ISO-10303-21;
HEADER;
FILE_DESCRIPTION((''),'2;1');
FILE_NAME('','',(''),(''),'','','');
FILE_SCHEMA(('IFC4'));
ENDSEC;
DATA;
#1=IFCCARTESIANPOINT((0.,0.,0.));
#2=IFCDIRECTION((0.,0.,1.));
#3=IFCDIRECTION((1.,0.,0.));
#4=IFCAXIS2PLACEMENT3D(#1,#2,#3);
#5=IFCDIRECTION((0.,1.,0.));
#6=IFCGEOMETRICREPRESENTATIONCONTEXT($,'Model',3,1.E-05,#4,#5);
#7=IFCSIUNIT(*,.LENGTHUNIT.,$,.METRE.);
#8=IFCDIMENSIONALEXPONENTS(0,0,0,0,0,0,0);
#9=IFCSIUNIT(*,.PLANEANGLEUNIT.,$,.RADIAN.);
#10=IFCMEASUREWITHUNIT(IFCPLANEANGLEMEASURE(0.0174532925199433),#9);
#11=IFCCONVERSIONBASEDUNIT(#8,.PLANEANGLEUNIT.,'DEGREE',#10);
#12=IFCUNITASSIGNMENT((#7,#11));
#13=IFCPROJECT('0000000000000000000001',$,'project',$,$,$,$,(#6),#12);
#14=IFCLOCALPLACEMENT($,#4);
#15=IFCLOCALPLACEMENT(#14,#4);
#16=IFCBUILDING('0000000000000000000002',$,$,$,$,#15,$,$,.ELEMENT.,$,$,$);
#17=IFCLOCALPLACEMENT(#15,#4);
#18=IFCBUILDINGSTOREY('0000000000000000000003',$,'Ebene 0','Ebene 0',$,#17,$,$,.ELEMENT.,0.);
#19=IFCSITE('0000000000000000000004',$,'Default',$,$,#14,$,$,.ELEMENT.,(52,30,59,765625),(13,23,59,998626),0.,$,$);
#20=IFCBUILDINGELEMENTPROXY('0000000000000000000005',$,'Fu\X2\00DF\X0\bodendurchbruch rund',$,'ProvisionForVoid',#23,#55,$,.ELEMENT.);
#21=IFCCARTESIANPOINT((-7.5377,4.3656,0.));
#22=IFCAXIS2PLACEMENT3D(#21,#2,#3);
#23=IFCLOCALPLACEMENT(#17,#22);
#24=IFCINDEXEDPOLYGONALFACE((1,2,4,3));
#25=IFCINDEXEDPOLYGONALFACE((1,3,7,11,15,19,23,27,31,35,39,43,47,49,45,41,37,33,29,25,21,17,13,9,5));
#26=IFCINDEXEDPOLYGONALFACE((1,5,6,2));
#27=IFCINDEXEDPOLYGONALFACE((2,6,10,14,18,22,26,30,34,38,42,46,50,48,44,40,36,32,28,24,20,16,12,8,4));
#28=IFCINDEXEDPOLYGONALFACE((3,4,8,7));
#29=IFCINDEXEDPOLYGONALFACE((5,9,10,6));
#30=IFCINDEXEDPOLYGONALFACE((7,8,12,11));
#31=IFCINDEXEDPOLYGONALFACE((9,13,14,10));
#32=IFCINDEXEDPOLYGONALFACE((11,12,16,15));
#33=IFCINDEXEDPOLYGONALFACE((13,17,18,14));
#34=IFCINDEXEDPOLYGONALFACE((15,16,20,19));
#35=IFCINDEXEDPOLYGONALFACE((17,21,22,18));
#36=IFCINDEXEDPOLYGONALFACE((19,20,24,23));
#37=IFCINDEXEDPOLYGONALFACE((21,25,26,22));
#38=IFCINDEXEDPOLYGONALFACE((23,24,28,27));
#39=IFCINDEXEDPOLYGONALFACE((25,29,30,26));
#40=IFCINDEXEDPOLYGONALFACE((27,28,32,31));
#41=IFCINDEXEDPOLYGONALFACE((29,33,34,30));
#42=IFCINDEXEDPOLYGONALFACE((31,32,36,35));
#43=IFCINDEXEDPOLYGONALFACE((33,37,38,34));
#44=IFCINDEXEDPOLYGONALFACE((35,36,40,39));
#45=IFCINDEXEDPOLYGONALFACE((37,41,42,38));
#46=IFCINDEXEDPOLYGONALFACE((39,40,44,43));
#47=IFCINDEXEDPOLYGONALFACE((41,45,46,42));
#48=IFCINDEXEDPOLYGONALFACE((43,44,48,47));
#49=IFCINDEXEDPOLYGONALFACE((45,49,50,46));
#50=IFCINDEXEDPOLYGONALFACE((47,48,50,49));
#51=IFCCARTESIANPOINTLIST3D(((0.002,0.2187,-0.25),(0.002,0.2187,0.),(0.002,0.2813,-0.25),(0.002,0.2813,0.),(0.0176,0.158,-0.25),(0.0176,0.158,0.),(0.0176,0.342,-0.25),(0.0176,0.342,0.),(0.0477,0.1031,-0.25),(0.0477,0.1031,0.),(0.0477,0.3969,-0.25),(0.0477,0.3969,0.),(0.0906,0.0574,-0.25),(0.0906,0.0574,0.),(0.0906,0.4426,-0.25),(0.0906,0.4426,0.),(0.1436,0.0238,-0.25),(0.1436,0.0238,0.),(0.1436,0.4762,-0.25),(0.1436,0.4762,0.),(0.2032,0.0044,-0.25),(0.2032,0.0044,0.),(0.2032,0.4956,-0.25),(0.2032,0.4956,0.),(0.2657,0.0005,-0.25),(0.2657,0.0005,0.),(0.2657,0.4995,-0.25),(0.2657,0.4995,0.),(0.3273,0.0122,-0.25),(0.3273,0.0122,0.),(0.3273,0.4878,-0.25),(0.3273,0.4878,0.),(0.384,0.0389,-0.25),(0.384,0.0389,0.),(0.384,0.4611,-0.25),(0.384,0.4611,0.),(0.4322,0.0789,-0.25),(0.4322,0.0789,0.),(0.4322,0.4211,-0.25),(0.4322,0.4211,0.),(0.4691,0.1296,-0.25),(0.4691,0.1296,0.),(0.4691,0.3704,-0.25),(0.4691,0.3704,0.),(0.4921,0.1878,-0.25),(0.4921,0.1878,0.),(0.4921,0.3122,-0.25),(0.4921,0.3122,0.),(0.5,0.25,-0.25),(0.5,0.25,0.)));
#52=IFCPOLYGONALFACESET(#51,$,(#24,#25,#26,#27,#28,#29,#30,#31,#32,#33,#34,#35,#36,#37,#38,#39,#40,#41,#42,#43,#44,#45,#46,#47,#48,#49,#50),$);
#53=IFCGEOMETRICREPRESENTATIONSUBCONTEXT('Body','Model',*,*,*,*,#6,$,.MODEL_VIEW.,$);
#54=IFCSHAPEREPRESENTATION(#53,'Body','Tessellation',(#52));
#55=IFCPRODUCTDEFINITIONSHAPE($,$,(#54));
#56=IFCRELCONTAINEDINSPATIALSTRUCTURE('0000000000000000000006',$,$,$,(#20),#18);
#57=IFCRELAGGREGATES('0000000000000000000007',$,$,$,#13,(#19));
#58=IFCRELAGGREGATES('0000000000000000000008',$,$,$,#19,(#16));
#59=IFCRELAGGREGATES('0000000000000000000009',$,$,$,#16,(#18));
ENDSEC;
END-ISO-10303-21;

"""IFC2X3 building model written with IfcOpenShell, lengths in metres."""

from ifc_helpers import new_model, entity, si_unit, converted_unit, direction, frame, origin_with_axes, origin_2d_with_axis, place, context, subcontext, project, spatial, circle, extrude, source, transform, mapped, element, save


model = new_model("IFC2X3")

# Units and contexts
model_context = context("Model", 3, precision=1e-05, world=origin_with_axes(), true_north=direction((0.0, 1.0, 0.0)))
body_context = subcontext(model_context, "Body", "Model", "MODEL_VIEW")
ifc_project = project(units=[si_unit("LENGTHUNIT", "METRE"), converted_unit("PLANEANGLEUNIT", "DEGREE", entity("IfcPlaneAngleMeasure", 0.0174532925199433), si_unit("PLANEANGLEUNIT", "RADIAN"), dimensions=[0, 0, 0, 0, 0, 0, 0])], contexts=[model_context])

# Site, building, storey
site_placement = place(None, origin_with_axes())
site = spatial("IfcSite", under=ifc_project, at=site_placement, Name="Default", CompositionType="ELEMENT", RefLatitude=(52, 30, 59, 765625), RefLongitude=(13, 23, 59, 998626), RefElevation=0.0)
building_placement = place(site_placement, origin_with_axes())
building = spatial("IfcBuilding", under=site, at=building_placement, CompositionType="ELEMENT")
storey_placement = place(building_placement, origin_with_axes())
storey = spatial("IfcBuildingStorey", under=building, at=storey_placement, Name="Ebene 0", Description="Ebene 0", CompositionType="ELEMENT", Elevation=0.0)

# Building element proxy
shared_shape_1 = source(origin_with_axes(), body_context, "Body", "SweptSolid", [
    extrude(circle(Radius=0.25, at=origin_2d_with_axis()), frame((0.25, 0.25, 0.0), z_axis=(0.0, 0.0, 1.0), x_axis=(1.0, 0.0, 0.0)), (0.0, 0.0, -1.0), 0.25),
])
proxy_1_placement = place(storey_placement, frame((-7.5377, 4.3656, 0.0), z_axis=(0.0, 0.0, 1.0), x_axis=(1.0, 0.0, 0.0)))
element("IfcBuildingElementProxy", 1, at=proxy_1_placement, inside=storey, Name="Fußbodendurchbruch rund", ObjectType="ProvisionForVoid", CompositionType="ELEMENT", context=body_context, shape_type="MappedRepresentation", body=[
    mapped(shared_shape_1, transform((0.0, 0.0, 0.0), x_axis=(1.0, 0.0, 0.0), y_axis=(0.0, 1.0, 0.0), z_axis=(0.0, 0.0, 1.0), scale=1.0)),
])

save(model, "model.ifc")
